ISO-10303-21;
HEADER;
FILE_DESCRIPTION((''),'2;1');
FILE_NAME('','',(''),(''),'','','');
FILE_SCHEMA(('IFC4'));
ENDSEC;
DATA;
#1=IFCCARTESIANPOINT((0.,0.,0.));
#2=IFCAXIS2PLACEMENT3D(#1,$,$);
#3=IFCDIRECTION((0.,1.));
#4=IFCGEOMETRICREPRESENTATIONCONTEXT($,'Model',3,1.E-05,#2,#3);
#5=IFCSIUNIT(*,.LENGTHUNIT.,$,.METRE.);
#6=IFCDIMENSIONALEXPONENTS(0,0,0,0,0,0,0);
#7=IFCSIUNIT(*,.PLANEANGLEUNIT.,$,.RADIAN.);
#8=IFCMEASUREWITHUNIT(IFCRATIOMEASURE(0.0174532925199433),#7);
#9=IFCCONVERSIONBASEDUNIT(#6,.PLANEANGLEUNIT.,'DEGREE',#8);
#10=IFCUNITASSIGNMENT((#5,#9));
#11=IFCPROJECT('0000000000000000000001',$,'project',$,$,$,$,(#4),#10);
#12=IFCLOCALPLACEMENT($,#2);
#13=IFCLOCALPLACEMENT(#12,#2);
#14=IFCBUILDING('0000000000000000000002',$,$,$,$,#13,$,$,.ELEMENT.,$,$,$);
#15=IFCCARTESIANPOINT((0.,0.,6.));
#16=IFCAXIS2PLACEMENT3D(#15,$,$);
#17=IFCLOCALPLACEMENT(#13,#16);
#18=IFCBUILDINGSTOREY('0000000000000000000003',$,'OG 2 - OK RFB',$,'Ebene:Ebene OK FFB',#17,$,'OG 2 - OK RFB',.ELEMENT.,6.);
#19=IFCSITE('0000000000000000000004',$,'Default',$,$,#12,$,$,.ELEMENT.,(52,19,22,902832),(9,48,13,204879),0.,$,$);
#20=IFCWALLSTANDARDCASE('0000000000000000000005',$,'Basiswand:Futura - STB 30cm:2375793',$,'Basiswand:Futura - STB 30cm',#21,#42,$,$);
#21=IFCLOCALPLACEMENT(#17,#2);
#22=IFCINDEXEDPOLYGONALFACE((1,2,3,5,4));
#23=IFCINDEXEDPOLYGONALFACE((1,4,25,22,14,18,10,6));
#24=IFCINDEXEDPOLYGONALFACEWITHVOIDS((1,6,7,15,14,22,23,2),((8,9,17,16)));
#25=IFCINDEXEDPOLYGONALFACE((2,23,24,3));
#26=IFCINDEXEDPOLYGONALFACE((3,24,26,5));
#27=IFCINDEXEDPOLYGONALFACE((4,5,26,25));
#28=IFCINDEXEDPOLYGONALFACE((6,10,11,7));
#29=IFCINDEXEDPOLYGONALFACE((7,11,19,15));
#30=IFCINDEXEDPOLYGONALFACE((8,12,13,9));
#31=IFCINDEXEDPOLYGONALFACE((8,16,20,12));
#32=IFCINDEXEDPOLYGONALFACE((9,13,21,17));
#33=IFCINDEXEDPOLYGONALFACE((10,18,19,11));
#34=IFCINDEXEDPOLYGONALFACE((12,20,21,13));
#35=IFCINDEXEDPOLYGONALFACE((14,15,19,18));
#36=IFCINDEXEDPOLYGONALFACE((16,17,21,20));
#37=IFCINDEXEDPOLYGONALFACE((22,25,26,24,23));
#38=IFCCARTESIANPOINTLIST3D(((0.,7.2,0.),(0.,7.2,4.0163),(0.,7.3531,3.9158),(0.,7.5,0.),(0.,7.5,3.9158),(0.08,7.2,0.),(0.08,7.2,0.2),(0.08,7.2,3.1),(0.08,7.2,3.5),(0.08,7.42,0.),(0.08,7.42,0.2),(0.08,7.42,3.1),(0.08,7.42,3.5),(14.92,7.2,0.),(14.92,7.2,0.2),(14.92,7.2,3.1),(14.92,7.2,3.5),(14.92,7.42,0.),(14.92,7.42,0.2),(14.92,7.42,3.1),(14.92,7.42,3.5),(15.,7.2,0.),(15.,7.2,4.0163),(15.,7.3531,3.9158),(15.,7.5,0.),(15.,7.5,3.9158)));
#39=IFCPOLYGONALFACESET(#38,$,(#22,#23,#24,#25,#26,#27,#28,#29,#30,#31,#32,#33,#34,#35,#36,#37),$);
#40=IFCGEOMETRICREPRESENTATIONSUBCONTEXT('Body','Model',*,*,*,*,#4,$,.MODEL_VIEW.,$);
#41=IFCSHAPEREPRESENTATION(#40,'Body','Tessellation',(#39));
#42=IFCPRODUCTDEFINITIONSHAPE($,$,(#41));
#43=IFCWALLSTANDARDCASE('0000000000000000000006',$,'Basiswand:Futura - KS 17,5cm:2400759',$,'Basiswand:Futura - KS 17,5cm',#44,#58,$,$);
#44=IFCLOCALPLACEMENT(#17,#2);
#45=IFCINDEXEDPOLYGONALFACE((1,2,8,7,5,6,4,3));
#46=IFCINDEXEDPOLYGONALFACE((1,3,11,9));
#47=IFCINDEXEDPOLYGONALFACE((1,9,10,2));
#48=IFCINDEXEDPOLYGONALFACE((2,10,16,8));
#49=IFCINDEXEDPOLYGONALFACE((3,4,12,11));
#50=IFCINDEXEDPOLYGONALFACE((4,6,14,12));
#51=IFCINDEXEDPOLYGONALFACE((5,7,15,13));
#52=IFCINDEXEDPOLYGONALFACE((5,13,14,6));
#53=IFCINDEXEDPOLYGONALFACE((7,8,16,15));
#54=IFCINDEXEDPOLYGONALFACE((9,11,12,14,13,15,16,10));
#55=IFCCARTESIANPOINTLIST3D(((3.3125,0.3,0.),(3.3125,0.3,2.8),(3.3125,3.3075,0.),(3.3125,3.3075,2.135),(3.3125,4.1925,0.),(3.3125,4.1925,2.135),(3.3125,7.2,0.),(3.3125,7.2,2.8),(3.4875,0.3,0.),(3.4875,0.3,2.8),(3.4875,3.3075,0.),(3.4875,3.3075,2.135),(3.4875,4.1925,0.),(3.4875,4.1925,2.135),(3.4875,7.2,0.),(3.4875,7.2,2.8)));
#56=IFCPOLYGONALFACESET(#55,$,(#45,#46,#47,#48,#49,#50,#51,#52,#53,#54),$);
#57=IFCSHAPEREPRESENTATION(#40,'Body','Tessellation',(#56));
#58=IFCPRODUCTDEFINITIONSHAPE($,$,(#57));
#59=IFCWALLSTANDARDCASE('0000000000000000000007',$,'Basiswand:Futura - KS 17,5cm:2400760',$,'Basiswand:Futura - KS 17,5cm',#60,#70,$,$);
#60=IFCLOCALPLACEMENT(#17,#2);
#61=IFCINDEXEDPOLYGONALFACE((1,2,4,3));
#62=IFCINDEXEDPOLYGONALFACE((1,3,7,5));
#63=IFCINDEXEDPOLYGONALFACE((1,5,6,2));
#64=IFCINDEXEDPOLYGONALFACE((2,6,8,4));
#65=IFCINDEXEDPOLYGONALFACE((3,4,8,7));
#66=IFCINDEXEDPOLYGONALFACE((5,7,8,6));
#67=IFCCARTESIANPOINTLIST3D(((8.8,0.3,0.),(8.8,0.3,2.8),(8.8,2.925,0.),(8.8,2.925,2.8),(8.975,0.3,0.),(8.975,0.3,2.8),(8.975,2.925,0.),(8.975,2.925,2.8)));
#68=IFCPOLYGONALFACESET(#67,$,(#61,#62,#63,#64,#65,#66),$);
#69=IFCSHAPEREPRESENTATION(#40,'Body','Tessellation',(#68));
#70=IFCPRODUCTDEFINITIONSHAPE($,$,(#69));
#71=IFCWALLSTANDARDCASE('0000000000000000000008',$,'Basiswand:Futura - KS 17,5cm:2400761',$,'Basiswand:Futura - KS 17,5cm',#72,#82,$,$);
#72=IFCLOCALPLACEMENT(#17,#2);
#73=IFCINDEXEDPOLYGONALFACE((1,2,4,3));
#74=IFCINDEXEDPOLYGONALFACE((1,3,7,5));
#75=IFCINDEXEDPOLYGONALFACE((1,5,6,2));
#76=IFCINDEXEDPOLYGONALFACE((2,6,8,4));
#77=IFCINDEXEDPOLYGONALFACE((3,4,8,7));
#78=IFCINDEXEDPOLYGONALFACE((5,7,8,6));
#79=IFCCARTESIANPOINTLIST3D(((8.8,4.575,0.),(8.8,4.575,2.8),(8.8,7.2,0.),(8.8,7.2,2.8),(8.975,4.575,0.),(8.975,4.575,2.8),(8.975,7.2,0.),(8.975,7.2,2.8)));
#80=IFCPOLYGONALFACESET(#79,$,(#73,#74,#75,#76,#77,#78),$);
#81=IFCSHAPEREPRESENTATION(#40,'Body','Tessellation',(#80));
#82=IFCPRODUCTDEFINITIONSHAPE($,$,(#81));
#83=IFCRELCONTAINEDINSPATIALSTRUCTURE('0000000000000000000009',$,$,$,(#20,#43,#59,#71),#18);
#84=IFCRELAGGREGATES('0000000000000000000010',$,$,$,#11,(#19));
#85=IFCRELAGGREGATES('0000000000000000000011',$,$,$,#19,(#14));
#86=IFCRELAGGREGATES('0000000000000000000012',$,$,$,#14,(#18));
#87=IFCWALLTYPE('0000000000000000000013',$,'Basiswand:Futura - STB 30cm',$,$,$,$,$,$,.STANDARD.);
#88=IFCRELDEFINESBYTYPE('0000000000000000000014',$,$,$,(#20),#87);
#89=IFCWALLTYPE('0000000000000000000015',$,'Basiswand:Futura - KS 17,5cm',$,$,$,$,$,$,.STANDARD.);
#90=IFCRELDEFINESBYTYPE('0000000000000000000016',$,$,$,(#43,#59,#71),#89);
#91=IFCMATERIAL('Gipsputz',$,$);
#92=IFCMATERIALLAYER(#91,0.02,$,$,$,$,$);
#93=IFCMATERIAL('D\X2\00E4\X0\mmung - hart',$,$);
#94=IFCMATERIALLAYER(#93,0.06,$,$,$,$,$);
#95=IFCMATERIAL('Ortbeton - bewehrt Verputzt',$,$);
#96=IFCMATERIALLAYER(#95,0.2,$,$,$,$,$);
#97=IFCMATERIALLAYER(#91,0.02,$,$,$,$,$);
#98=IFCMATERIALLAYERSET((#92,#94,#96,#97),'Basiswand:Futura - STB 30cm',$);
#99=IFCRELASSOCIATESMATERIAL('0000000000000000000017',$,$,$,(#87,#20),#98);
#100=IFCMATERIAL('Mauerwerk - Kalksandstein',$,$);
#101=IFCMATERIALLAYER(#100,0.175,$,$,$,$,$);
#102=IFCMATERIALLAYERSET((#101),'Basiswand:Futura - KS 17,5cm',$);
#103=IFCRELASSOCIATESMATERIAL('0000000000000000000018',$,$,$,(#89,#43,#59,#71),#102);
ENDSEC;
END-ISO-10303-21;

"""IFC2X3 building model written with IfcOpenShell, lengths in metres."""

from ifc_helpers import new_model, entity, si_unit, converted_unit, direction, frame, frame_2d, origin, origin_2d_with_axis, place, context, subcontext, project, spatial, polyline, rectangle, extrude, clip, bounded_halfspace, material, layer, layer_set, layer_usage, type_object, element, save


model = new_model("IFC2X3")

# Units and contexts
model_context = context("Model", 3, precision=1e-05, world=origin(), true_north=direction((0.0, 1.0)))
body_context = subcontext(model_context, "Body", "Model", "MODEL_VIEW")
ifc_project = project(units=[si_unit("LENGTHUNIT", "METRE"), converted_unit("PLANEANGLEUNIT", "DEGREE", entity("IfcRatioMeasure", 0.0174532925199433), si_unit("PLANEANGLEUNIT", "RADIAN"), dimensions=[0, 0, 0, 0, 0, 0, 0])], contexts=[model_context])

# Site, building, storey
site_placement = place(None, frame((0.0, 0.0, 0.0)))
site = spatial("IfcSite", under=ifc_project, at=site_placement, Name="Default", CompositionType="ELEMENT", RefLatitude=(52, 19, 22, 902832), RefLongitude=(9, 48, 13, 204879), RefElevation=0.0)
building_placement = place(site_placement, origin())
building = spatial("IfcBuilding", under=site, at=building_placement, CompositionType="ELEMENT")
storey_placement = place(building_placement, frame((0.0, 0.0, 6.0)))
storey = spatial("IfcBuildingStorey", under=building, at=storey_placement, Name="OG 2 - OK RFB", ObjectType="Ebene:Ebene OK FFB", LongName="OG 2 - OK RFB", CompositionType="ELEMENT", Elevation=6.0)

# Wall, openings
ifc_material_1 = material(Name="Gipsputz")
ifc_layer_1 = layer(ifc_material_1, 0.02)
ifc_material_2 = material(Name="Dämmung - hart")
ifc_layer_2 = layer(ifc_material_2, 0.06)
ifc_material_3 = material(Name="Ortbeton - bewehrt Verputzt")
ifc_layer_3 = layer(ifc_material_3, 0.2)
ifc_layer_4 = layer(ifc_material_1, 0.02)
ifc_layer_set_1 = layer_set([ifc_layer_1, ifc_layer_2, ifc_layer_3, ifc_layer_4], Name="Basiswand:Futura - STB 30cm")
ifc_layer_usage_1 = layer_usage(ifc_layer_set_1, "AXIS2", "POSITIVE", -0.15)
wall_type_1 = type_object("IfcWallType", Name="Basiswand:Futura - STB 30cm", PredefinedType="STANDARD", material=ifc_layer_set_1)
wall_1_placement = place(storey_placement, frame((15.0, 7.35, 0.0), z_axis=(0.0, 0.0, 1.0), x_axis=(-1.0, 0.0, 0.0)))
wall_1 = element("IfcWallStandardCase", 1, at=wall_1_placement, inside=storey, type_object=wall_type_1, material=ifc_layer_usage_1, Name="Basiswand:Futura - STB 30cm:2375793", ObjectType="Basiswand:Futura - STB 30cm", context=body_context, shape_type="Clipping", body=[
    clip(clip(extrude(rectangle(XDim=15.0, YDim=0.3, at=frame_2d((7.5, 0.0), x_axis=(-1.0, 0.0))), origin(), (0.0, 0.0, 1.0), 4.0163), bounded_halfspace(frame((15.0, 0.15, 4.0163), z_axis=(0.0, -0.548588, 0.836093), x_axis=(1.0, 0.0, 0.0)), False, frame((15.0, 0.15, 4.0163)), polyline([(0.0, 0.0), (-0.3, 0.0), (-14.7, 0.0), (-15.0, 0.0), (-15.0, -0.1531), (0.0, -0.1531), (0.0, 0.0)]))), bounded_halfspace(frame((0.0, -0.15, 3.9158), z_axis=(0.0, 0.0, -1.0), x_axis=(1.0, 0.0, 0.0)), True, frame((0.0, -0.15, 3.9158)), polyline([(0.0, 0.0), (15.0, 0.0), (15.0, 0.1469), (0.0, 0.1469), (0.0, 0.0)]))),
])
opening_1_placement = place(storey_placement, frame((15.0, 7.35, 0.0), z_axis=(0.0, 0.0, 1.0), x_axis=(-1.0, 0.0, 0.0)))
element("IfcOpeningElement", 2, at=opening_1_placement, cuts=wall_1, ObjectType="Opening", context=body_context, shape_type="SweptSolid", body=[
    extrude(rectangle(XDim=14.84, YDim=0.22, at=frame_2d((0.0, -0.0367), x_axis=(1.0, 0.0))), frame((7.5, 0.0767, 3.1)), (0.0, 0.0, 1.0), 0.4),
])
opening_2_placement = place(storey_placement, frame((15.0, 7.35, 0.0), z_axis=(0.0, 0.0, 1.0), x_axis=(-1.0, 0.0, 0.0)))
element("IfcOpeningElement", 3, at=opening_2_placement, cuts=wall_1, ObjectType="Opening", context=body_context, shape_type="SweptSolid", body=[
    extrude(rectangle(XDim=0.2, YDim=0.22, at=origin_2d_with_axis()), frame((14.92, 0.04, 0.1), z_axis=(-1.0, 0.0, 0.0), x_axis=(0.0, 0.0, 1.0)), (0.0, 0.0, 1.0), 14.84),
])
ifc_material_4 = material(Name="Mauerwerk - Kalksandstein")
ifc_layer_5 = layer(ifc_material_4, 0.175)
ifc_layer_set_2 = layer_set([ifc_layer_5], Name="Basiswand:Futura - KS 17,5cm")
wall_type_2 = type_object("IfcWallType", Name="Basiswand:Futura - KS 17,5cm", PredefinedType="STANDARD", material=ifc_layer_set_2)

# Wall, opening
ifc_layer_usage_2 = layer_usage(ifc_layer_set_2, "AXIS2", "NEGATIVE", 0.0875)
wall_2_placement = place(storey_placement, frame((3.4, 0.3, 0.0), z_axis=(0.0, 0.0, 1.0), x_axis=(0.0, 1.0, 0.0)))
wall_2 = element("IfcWallStandardCase", 4, at=wall_2_placement, inside=storey, type_object=wall_type_2, material=ifc_layer_usage_2, Name="Basiswand:Futura - KS 17,5cm:2400759", ObjectType="Basiswand:Futura - KS 17,5cm", context=body_context, shape_type="SweptSolid", body=[
    extrude(rectangle(XDim=6.9, YDim=0.175, at=frame_2d((3.45, 0.0), x_axis=(-1.0, 0.0))), origin(), (0.0, 0.0, 1.0), 2.8),
])
opening_3_placement = place(wall_2_placement, frame((3.8925, 0.0875, -0.18)))
element("IfcOpeningElement", 5, at=opening_3_placement, cuts=wall_2, ObjectType="Opening", context=body_context, shape_type="SweptSolid", body=[
    extrude(rectangle(XDim=2.315, YDim=0.885, at=frame_2d((1.1575, 0.4425), x_axis=(-1.0, 0.0))), frame((0.0, 0.0, 0.0), z_axis=(0.0, -1.0, 0.0), x_axis=(0.0, 0.0, 1.0)), (0.0, 0.0, 1.0), 0.175),
])

# Walls
ifc_layer_usage_3 = layer_usage(ifc_layer_set_2, "AXIS2", "NEGATIVE", 0.0875)
wall_3_placement = place(storey_placement, frame((8.8875, 0.3, 0.0), z_axis=(0.0, 0.0, 1.0), x_axis=(0.0, 1.0, 0.0)))
element("IfcWallStandardCase", 6, at=wall_3_placement, inside=storey, type_object=wall_type_2, material=ifc_layer_usage_3, Name="Basiswand:Futura - KS 17,5cm:2400760", ObjectType="Basiswand:Futura - KS 17,5cm", context=body_context, shape_type="SweptSolid", body=[
    extrude(rectangle(XDim=2.625, YDim=0.175, at=frame_2d((1.3125, 0.0), x_axis=(-1.0, 0.0))), origin(), (0.0, 0.0, 1.0), 2.8),
])
ifc_layer_usage_4 = layer_usage(ifc_layer_set_2, "AXIS2", "NEGATIVE", 0.0875)
wall_4_placement = place(storey_placement, frame((8.8875, 4.575, 0.0), z_axis=(0.0, 0.0, 1.0), x_axis=(0.0, 1.0, 0.0)))
element("IfcWallStandardCase", 7, at=wall_4_placement, inside=storey, type_object=wall_type_2, material=ifc_layer_usage_4, Name="Basiswand:Futura - KS 17,5cm:2400761", ObjectType="Basiswand:Futura - KS 17,5cm", context=body_context, shape_type="SweptSolid", body=[
    extrude(rectangle(XDim=2.625, YDim=0.175, at=frame_2d((1.3125, 0.0), x_axis=(-1.0, 0.0))), origin(), (0.0, 0.0, 1.0), 2.8),
])

save(model, "model.ifc")
